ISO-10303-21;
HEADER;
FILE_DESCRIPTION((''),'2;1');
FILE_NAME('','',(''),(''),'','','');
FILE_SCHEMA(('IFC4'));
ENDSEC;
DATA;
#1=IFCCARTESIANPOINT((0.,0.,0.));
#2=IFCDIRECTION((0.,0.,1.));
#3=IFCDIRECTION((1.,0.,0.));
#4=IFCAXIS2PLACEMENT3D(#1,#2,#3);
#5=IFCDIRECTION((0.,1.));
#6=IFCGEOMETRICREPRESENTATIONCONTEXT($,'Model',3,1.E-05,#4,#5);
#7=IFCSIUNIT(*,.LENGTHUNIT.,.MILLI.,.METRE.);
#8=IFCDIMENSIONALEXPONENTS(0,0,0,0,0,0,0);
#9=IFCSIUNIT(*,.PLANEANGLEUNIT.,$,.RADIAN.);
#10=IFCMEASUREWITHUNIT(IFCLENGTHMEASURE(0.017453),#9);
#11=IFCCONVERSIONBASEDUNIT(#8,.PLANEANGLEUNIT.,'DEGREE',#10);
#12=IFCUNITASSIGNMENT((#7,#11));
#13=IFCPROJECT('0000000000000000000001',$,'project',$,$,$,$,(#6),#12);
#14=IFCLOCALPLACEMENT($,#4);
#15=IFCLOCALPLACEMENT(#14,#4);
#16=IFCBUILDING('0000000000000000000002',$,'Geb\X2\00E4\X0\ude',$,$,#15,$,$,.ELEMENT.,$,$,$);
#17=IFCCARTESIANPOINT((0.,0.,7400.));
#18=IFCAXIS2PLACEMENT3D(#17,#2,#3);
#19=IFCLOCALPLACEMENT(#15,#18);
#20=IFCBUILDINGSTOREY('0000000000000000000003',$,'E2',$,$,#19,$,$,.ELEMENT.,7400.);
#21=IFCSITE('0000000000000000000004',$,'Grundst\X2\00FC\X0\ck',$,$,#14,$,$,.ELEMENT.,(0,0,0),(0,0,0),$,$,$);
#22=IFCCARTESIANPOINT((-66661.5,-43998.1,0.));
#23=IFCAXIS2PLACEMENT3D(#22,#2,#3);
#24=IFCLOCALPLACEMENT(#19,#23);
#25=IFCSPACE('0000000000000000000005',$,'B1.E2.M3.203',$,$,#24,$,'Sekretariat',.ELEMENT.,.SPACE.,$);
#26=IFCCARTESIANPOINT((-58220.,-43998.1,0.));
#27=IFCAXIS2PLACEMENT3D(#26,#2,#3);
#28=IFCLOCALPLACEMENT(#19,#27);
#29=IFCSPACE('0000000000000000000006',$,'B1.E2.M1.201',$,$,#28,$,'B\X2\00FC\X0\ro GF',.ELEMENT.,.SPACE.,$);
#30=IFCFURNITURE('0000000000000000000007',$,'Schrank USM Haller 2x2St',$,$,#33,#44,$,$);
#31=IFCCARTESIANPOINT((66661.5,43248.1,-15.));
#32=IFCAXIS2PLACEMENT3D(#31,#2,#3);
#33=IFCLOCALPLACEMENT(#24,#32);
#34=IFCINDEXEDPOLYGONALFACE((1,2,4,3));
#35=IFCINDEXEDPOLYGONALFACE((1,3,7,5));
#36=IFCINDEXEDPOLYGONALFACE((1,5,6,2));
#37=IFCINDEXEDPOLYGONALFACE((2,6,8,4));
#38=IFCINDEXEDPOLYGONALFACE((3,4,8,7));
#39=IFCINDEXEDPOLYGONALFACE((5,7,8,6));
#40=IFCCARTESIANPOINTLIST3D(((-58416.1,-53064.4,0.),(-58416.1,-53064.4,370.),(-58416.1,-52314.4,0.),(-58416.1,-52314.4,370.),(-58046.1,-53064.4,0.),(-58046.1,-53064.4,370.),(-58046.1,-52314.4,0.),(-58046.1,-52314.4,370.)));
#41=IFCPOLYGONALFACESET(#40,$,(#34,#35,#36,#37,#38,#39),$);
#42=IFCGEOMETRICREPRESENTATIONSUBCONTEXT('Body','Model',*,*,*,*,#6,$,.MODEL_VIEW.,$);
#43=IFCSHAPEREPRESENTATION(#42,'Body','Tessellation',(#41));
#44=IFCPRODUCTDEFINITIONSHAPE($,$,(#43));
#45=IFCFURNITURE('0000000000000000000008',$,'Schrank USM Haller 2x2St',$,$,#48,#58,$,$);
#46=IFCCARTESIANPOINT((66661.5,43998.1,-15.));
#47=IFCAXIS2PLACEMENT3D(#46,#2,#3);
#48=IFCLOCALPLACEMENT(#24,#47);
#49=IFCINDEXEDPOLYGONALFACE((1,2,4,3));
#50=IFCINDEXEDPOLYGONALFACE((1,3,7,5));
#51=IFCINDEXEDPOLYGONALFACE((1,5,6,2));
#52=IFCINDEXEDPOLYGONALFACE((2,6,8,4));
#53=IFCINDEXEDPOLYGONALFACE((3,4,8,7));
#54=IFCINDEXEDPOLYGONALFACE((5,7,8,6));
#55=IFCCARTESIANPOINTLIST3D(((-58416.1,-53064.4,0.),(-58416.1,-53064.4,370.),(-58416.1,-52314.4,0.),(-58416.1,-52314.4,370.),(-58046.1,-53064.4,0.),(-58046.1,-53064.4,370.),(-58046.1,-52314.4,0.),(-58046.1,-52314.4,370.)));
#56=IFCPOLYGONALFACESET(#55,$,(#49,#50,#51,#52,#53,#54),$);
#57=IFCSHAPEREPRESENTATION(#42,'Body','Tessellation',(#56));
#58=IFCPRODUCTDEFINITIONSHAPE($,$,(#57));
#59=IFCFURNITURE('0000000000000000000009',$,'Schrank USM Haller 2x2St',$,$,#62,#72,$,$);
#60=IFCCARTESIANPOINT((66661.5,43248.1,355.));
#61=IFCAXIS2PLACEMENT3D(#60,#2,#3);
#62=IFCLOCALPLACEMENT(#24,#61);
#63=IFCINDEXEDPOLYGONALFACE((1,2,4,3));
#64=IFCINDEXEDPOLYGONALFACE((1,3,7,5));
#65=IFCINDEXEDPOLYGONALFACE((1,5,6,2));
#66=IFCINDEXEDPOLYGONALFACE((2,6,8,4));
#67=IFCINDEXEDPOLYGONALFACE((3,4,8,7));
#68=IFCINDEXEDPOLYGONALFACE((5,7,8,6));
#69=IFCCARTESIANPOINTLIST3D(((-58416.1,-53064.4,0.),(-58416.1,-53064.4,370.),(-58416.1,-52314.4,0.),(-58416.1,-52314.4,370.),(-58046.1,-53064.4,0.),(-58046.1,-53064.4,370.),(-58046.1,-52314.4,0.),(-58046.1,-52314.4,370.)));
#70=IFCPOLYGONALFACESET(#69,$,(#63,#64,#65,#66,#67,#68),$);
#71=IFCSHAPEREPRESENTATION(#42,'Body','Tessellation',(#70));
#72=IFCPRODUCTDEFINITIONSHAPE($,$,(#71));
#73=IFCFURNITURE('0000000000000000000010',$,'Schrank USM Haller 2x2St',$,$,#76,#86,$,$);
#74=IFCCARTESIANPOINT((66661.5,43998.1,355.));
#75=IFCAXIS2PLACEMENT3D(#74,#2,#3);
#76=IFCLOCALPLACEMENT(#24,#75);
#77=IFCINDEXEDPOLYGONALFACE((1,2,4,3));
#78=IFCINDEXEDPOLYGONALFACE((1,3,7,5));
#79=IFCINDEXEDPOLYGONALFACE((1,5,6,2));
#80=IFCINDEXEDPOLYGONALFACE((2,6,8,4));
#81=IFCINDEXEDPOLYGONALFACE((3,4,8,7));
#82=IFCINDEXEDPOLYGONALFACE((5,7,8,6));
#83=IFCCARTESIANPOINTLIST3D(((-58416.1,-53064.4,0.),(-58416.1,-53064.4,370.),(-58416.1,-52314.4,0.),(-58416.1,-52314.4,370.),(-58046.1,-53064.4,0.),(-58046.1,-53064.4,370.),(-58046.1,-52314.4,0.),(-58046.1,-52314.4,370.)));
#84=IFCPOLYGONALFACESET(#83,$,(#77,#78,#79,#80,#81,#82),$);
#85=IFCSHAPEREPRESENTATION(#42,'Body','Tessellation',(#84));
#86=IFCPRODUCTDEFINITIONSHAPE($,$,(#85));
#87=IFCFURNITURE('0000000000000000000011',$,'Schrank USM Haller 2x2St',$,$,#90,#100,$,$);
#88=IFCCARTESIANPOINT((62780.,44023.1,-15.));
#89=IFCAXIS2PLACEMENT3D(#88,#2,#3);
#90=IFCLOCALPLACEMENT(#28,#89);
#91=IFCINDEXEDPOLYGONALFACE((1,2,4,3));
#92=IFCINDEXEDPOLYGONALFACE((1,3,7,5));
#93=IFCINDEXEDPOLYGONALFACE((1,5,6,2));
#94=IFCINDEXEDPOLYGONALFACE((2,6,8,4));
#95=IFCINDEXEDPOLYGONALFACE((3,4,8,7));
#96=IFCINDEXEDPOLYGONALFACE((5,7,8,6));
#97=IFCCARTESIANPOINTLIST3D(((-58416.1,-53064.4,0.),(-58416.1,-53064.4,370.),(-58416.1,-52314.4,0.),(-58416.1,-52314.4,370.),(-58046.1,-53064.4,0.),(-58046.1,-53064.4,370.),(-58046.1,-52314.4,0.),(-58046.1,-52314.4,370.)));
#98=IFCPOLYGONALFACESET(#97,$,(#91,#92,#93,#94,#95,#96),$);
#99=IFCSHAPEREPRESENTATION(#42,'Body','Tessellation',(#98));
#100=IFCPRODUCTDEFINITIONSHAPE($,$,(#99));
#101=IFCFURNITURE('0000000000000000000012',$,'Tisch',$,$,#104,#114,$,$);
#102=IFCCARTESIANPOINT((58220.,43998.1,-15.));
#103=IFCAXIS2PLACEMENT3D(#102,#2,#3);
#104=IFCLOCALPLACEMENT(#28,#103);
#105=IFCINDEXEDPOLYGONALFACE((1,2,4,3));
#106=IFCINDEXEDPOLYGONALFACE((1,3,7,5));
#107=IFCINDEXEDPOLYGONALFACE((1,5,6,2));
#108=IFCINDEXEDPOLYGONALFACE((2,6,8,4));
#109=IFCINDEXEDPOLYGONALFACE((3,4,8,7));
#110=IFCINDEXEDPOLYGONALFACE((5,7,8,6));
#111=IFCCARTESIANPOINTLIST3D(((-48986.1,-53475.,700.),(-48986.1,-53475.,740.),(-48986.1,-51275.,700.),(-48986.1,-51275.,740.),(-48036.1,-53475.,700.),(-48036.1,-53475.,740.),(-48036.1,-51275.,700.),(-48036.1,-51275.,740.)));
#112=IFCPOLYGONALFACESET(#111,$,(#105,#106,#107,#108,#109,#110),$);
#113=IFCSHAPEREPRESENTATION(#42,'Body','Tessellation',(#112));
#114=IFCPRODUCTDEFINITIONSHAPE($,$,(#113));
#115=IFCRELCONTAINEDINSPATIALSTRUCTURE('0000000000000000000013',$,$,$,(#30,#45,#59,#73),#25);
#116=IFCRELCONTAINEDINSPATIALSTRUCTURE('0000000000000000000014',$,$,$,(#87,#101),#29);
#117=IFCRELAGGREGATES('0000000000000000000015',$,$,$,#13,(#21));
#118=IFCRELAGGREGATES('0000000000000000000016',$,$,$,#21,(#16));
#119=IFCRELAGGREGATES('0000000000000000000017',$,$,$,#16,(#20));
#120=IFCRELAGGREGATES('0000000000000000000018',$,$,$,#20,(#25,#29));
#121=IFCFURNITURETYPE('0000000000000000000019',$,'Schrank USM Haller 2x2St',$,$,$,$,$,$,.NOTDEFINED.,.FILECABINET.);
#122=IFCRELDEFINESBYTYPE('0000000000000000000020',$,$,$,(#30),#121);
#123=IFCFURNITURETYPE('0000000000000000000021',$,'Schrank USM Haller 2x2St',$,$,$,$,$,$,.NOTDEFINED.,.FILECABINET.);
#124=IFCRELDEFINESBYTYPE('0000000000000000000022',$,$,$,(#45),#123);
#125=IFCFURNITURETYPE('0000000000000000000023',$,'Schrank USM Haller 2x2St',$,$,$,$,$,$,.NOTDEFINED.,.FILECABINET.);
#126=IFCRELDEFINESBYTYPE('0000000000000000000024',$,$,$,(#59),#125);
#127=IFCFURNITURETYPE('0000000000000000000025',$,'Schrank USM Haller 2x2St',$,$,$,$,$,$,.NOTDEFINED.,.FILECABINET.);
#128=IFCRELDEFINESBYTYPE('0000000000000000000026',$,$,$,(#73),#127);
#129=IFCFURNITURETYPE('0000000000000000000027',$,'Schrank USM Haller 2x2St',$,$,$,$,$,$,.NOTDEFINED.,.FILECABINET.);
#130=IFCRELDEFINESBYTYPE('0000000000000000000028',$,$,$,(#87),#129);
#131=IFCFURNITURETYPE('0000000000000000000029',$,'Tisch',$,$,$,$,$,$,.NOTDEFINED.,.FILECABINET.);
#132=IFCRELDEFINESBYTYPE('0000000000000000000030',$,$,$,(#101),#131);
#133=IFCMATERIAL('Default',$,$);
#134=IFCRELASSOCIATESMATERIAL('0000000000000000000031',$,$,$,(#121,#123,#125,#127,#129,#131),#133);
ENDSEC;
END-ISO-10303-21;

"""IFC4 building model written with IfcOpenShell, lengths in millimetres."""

from ifc_helpers import new_model, entity, si_unit, converted_unit, direction, frame, origin_with_axes, place, context, subcontext, project, spatial, line, indexed_curve, outline, extrude, material, type_object, element, save


model = new_model("IFC4")

# Units and contexts
model_context = context("Model", 3, precision=1e-05, world=origin_with_axes(), true_north=direction((0.0, 1.0)))
body_context = subcontext(model_context, "Body", "Model", "MODEL_VIEW")
ifc_project = project(units=[si_unit("LENGTHUNIT", "METRE", prefix="MILLI"), converted_unit("PLANEANGLEUNIT", "DEGREE", entity("IfcLengthMeasure", 0.017453), si_unit("PLANEANGLEUNIT", "RADIAN"), dimensions=[0, 0, 0, 0, 0, 0, 0])], contexts=[model_context])

# Site, building, storey
site_placement = place(None, origin_with_axes())
site = spatial("IfcSite", under=ifc_project, at=site_placement, Name="Grundstück", CompositionType="ELEMENT", RefLatitude=(0, 0, 0), RefLongitude=(0, 0, 0))
building_placement = place(site_placement, origin_with_axes())
building = spatial("IfcBuilding", under=site, at=building_placement, Name="Gebäude", CompositionType="ELEMENT")
storey_placement = place(building_placement, frame((0.0, 0.0, 7400.0), z_axis=(0.0, 0.0, 1.0), x_axis=(1.0, 0.0, 0.0)))
storey = spatial("IfcBuildingStorey", under=building, at=storey_placement, Name="E2", CompositionType="ELEMENT", Elevation=7400.0)

# Shared definitions
space_1_placement = place(storey_placement, frame((-66661.5, -43998.1, 0.0), z_axis=(0.0, 0.0, 1.0), x_axis=(1.0, 0.0, 0.0)))
space_1 = spatial("IfcSpace", under=storey, at=space_1_placement, Name="B1.E2.M3.203", LongName="Sekretariat", CompositionType="ELEMENT", PredefinedType="SPACE")

# Furniture
ifc_material = material(Name="Default")
furniture_type_1 = type_object("IfcFurnitureType", Name="Schrank USM Haller 2x2St", AssemblyPlace="NOTDEFINED", PredefinedType="FILECABINET", material=ifc_material)
furniture_1_placement = place(space_1_placement, frame((66661.5, 43248.1, -15.0), z_axis=(0.0, 0.0, 1.0), x_axis=(1.0, 0.0, 0.0)))
element("IfcFurniture", 1, at=furniture_1_placement, inside=space_1, type_object=furniture_type_1, Name="Schrank USM Haller 2x2St", context=body_context, shape_type="SweptSolid", body=[
    extrude(outline(indexed_curve([(-58416.1, -53064.4), (-58046.1, -53064.4), (-58046.1, -52314.4), (-58416.1, -52314.4)], segments=[line(1, 2), line(2, 3), line(3, 4), line(4, 1)])), origin_with_axes(), (0.0, 0.0, 1.0), 370.0),
])
furniture_type_2 = type_object("IfcFurnitureType", Name="Schrank USM Haller 2x2St", AssemblyPlace="NOTDEFINED", PredefinedType="FILECABINET", material=ifc_material)
furniture_2_placement = place(space_1_placement, frame((66661.5, 43998.1, -15.0), z_axis=(0.0, 0.0, 1.0), x_axis=(1.0, 0.0, 0.0)))
element("IfcFurniture", 2, at=furniture_2_placement, inside=space_1, type_object=furniture_type_2, Name="Schrank USM Haller 2x2St", context=body_context, shape_type="SweptSolid", body=[
    extrude(outline(indexed_curve([(-58416.1, -53064.4), (-58046.1, -53064.4), (-58046.1, -52314.4), (-58416.1, -52314.4)], segments=[line(1, 2), line(2, 3), line(3, 4), line(4, 1)])), origin_with_axes(), (0.0, 0.0, 1.0), 370.0),
])
furniture_type_3 = type_object("IfcFurnitureType", Name="Schrank USM Haller 2x2St", AssemblyPlace="NOTDEFINED", PredefinedType="FILECABINET", material=ifc_material)
furniture_3_placement = place(space_1_placement, frame((66661.5, 43248.1, 355.0), z_axis=(0.0, 0.0, 1.0), x_axis=(1.0, 0.0, 0.0)))
element("IfcFurniture", 3, at=furniture_3_placement, inside=space_1, type_object=furniture_type_3, Name="Schrank USM Haller 2x2St", context=body_context, shape_type="SweptSolid", body=[
    extrude(outline(indexed_curve([(-58416.1, -53064.4), (-58046.1, -53064.4), (-58046.1, -52314.4), (-58416.1, -52314.4)], segments=[line(1, 2), line(2, 3), line(3, 4), line(4, 1)])), origin_with_axes(), (0.0, 0.0, 1.0), 370.0),
])
furniture_type_4 = type_object("IfcFurnitureType", Name="Schrank USM Haller 2x2St", AssemblyPlace="NOTDEFINED", PredefinedType="FILECABINET", material=ifc_material)
furniture_4_placement = place(space_1_placement, frame((66661.5, 43998.1, 355.0), z_axis=(0.0, 0.0, 1.0), x_axis=(1.0, 0.0, 0.0)))
element("IfcFurniture", 4, at=furniture_4_placement, inside=space_1, type_object=furniture_type_4, Name="Schrank USM Haller 2x2St", context=body_context, shape_type="SweptSolid", body=[
    extrude(outline(indexed_curve([(-58416.1, -53064.4), (-58046.1, -53064.4), (-58046.1, -52314.4), (-58416.1, -52314.4)], segments=[line(1, 2), line(2, 3), line(3, 4), line(4, 1)])), origin_with_axes(), (0.0, 0.0, 1.0), 370.0),
])

# Shared definitions
space_2_placement = place(storey_placement, frame((-58220.0, -43998.1, 0.0), z_axis=(0.0, 0.0, 1.0), x_axis=(1.0, 0.0, 0.0)))
space_2 = spatial("IfcSpace", under=storey, at=space_2_placement, Name="B1.E2.M1.201", LongName="Büro GF", CompositionType="ELEMENT", PredefinedType="SPACE")

# Furniture
furniture_type_5 = type_object("IfcFurnitureType", Name="Schrank USM Haller 2x2St", AssemblyPlace="NOTDEFINED", PredefinedType="FILECABINET", material=ifc_material)
furniture_5_placement = place(space_2_placement, frame((62780.0, 44023.1, -15.0), z_axis=(0.0, 0.0, 1.0), x_axis=(1.0, 0.0, 0.0)))
element("IfcFurniture", 5, at=furniture_5_placement, inside=space_2, type_object=furniture_type_5, Name="Schrank USM Haller 2x2St", context=body_context, shape_type="SweptSolid", body=[
    extrude(outline(indexed_curve([(-58416.1, -53064.4), (-58046.1, -53064.4), (-58046.1, -52314.4), (-58416.1, -52314.4)], segments=[line(1, 2), line(2, 3), line(3, 4), line(4, 1)])), origin_with_axes(), (0.0, 0.0, 1.0), 370.0),
])
furniture_type_6 = type_object("IfcFurnitureType", Name="Tisch", AssemblyPlace="NOTDEFINED", PredefinedType="FILECABINET", material=ifc_material)
furniture_6_placement = place(space_2_placement, frame((58220.0, 43998.1, -15.0), z_axis=(0.0, 0.0, 1.0), x_axis=(1.0, 0.0, 0.0)))
element("IfcFurniture", 6, at=furniture_6_placement, inside=space_2, type_object=furniture_type_6, Name="Tisch", context=body_context, shape_type="SweptSolid", body=[
    extrude(outline(indexed_curve([(-48036.1, -51275.0), (-48986.1, -51275.0), (-48986.1, -53475.0), (-48036.1, -53475.0)], segments=[line(1, 2), line(2, 3), line(3, 4), line(4, 1)])), frame((0.0, 0.0, 700.0), z_axis=(0.0, 0.0, 1.0), x_axis=(1.0, 0.0, 0.0)), (0.0, 0.0, 1.0), 40.0),
])

save(model, "model.ifc")
